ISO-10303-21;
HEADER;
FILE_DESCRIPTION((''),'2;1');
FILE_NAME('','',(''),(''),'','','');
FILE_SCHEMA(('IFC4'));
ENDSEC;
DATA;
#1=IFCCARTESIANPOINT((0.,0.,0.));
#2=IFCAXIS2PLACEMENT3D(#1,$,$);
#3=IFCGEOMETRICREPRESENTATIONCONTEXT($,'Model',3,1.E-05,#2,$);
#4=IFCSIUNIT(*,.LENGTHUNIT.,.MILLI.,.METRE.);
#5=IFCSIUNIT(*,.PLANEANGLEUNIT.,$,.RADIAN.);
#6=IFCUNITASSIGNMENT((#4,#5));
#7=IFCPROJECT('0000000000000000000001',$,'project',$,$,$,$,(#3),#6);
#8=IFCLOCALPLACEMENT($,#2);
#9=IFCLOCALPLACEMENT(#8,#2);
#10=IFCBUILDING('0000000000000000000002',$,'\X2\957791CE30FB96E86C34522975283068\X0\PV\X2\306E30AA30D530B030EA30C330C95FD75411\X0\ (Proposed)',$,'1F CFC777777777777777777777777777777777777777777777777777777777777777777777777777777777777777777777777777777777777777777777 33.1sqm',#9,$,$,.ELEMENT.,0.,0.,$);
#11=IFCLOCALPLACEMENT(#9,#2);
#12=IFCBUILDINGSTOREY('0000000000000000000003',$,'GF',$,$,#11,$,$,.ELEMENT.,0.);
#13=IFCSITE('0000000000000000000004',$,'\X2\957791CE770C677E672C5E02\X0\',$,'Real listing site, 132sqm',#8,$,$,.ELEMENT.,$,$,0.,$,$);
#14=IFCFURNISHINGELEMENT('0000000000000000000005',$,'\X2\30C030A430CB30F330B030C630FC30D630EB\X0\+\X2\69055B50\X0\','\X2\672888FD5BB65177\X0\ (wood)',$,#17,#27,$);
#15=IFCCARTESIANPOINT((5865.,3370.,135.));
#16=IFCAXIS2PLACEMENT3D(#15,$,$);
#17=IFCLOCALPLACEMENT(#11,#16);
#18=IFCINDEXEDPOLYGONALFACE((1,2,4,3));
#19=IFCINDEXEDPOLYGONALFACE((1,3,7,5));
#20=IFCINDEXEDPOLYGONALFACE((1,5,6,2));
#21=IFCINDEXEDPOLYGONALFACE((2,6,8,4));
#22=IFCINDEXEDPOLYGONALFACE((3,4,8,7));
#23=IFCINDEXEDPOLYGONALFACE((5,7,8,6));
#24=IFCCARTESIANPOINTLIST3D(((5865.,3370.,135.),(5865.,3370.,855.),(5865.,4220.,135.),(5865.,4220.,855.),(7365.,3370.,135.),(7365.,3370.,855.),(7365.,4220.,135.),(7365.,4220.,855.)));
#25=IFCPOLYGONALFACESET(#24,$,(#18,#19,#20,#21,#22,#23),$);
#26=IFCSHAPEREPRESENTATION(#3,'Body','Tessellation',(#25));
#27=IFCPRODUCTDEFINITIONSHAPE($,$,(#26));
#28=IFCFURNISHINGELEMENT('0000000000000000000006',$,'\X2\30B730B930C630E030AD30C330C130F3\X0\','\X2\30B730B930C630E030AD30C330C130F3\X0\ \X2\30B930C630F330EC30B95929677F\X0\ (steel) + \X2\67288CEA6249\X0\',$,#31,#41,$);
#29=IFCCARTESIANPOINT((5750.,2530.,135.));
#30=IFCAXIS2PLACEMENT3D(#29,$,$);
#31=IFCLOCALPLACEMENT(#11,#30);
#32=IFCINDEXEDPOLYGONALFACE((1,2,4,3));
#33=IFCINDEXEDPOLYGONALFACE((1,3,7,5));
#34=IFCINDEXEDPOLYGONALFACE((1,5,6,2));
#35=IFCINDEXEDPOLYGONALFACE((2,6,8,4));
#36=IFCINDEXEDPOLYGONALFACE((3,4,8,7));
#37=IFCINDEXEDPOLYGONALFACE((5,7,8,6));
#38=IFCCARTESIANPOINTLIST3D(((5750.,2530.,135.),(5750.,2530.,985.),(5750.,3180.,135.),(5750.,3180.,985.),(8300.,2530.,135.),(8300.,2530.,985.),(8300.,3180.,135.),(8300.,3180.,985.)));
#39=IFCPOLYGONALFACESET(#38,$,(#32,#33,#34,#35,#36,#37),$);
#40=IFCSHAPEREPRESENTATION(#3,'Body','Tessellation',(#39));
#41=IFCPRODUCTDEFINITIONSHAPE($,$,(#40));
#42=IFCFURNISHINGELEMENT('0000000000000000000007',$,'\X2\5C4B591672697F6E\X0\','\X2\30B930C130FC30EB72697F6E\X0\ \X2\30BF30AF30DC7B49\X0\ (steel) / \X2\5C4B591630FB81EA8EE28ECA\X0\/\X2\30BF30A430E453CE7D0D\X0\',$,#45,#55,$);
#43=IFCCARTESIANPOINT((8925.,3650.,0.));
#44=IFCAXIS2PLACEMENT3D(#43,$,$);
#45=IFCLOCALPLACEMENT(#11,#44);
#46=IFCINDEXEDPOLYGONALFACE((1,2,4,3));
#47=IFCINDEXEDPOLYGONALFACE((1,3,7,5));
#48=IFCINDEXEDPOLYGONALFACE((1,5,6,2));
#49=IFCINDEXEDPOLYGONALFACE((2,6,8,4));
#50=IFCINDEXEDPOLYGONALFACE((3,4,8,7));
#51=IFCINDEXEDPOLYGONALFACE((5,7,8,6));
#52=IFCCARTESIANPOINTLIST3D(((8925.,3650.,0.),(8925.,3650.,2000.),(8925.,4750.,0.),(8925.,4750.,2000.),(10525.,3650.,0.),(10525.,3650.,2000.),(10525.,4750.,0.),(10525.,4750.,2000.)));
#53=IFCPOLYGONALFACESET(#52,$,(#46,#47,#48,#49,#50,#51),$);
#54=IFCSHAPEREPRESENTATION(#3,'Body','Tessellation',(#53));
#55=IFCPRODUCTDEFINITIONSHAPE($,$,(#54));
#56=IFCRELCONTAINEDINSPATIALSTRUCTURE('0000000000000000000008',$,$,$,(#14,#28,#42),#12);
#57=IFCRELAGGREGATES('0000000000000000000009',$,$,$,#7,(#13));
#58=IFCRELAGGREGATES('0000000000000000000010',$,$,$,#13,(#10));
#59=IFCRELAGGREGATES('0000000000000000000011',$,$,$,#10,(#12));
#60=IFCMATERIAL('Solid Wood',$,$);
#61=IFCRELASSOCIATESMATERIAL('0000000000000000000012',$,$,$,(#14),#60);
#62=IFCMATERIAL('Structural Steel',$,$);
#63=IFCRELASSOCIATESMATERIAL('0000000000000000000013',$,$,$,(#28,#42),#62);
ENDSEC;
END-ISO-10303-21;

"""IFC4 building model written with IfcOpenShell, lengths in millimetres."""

from ifc_helpers import new_model, si_unit, frame, frame_2d, origin, place, context, project, spatial, rectangle, extrude, material, element, save


model = new_model("IFC4")

# Units and contexts
model_context = context("Model", 3, precision=1e-05, world=origin())
ifc_project = project(units=[si_unit("LENGTHUNIT", "METRE", prefix="MILLI"), si_unit("PLANEANGLEUNIT", "RADIAN")], contexts=[model_context])

# Site, building, storey
site_placement = place(None, origin())
site = spatial("IfcSite", under=ifc_project, at=site_placement, Name="長野県松本市", ObjectType="Real listing site, 132sqm", CompositionType="ELEMENT", RefElevation=0.0)
building_placement = place(site_placement, origin())
building = spatial("IfcBuilding", under=site, at=building_placement, Name="長野・雨水利用とPVのオフグリッド志向 (Proposed)", ObjectType="1F CFC777777777777777777777777777777777777777777777777777777777777777777777777777777777777777777777777777777777777777777777 33.1sqm", CompositionType="ELEMENT", ElevationOfRefHeight=0.0, ElevationOfTerrain=0.0)
storey_placement = place(building_placement, origin())
storey = spatial("IfcBuildingStorey", under=building, at=storey_placement, Name="GF", CompositionType="ELEMENT", Elevation=0.0)

# Shared definitions
ifc_material_1 = material(Name="Solid Wood")

# Shared definitions
ifc_material_2 = material(Name="Structural Steel")

# Furnishing elements
furnishing_1_placement = place(storey_placement, frame((5865.0, 3370.0, 135.0)))
element("IfcFurnishingElement", 1, at=furnishing_1_placement, inside=storey, material=ifc_material_1, Name="ダイニングテーブル+椅子", Description="木製家具 (wood)", context=model_context, shape_type="SweptSolid", body=[
    extrude(rectangle(XDim=1500.0, YDim=850.0, at=frame_2d((750.0, 425.0))), frame((5865.0, 3370.0, 135.0)), (0.0, 0.0, 1.0), 720.0),
])
furnishing_2_placement = place(storey_placement, frame((5750.0, 2530.0, 135.0)))
element("IfcFurnishingElement", 2, at=furnishing_2_placement, inside=storey, material=ifc_material_2, Name="システムキッチン", Description="システムキッチン ステンレス天板 (steel) + 木質扉", context=model_context, shape_type="SweptSolid", body=[
    extrude(rectangle(XDim=2550.0, YDim=650.0, at=frame_2d((1275.0, 325.0))), frame((5750.0, 2530.0, 135.0)), (0.0, 0.0, 1.0), 850.0),
])
furnishing_3_placement = place(storey_placement, frame((8925.0, 3650.0, 0.0)))
element("IfcFurnishingElement", 3, at=furnishing_3_placement, inside=storey, material=ifc_material_2, Name="屋外物置", Description="スチール物置 タクボ等 (steel) / 屋外・自転車/タイヤ収納", context=model_context, shape_type="SweptSolid", body=[
    extrude(rectangle(XDim=1600.0, YDim=1100.0, at=frame_2d((800.0, 550.0))), frame((8925.0, 3650.0, 0.0)), (0.0, 0.0, 1.0), 2000.0),
])

save(model, "model.ifc")
